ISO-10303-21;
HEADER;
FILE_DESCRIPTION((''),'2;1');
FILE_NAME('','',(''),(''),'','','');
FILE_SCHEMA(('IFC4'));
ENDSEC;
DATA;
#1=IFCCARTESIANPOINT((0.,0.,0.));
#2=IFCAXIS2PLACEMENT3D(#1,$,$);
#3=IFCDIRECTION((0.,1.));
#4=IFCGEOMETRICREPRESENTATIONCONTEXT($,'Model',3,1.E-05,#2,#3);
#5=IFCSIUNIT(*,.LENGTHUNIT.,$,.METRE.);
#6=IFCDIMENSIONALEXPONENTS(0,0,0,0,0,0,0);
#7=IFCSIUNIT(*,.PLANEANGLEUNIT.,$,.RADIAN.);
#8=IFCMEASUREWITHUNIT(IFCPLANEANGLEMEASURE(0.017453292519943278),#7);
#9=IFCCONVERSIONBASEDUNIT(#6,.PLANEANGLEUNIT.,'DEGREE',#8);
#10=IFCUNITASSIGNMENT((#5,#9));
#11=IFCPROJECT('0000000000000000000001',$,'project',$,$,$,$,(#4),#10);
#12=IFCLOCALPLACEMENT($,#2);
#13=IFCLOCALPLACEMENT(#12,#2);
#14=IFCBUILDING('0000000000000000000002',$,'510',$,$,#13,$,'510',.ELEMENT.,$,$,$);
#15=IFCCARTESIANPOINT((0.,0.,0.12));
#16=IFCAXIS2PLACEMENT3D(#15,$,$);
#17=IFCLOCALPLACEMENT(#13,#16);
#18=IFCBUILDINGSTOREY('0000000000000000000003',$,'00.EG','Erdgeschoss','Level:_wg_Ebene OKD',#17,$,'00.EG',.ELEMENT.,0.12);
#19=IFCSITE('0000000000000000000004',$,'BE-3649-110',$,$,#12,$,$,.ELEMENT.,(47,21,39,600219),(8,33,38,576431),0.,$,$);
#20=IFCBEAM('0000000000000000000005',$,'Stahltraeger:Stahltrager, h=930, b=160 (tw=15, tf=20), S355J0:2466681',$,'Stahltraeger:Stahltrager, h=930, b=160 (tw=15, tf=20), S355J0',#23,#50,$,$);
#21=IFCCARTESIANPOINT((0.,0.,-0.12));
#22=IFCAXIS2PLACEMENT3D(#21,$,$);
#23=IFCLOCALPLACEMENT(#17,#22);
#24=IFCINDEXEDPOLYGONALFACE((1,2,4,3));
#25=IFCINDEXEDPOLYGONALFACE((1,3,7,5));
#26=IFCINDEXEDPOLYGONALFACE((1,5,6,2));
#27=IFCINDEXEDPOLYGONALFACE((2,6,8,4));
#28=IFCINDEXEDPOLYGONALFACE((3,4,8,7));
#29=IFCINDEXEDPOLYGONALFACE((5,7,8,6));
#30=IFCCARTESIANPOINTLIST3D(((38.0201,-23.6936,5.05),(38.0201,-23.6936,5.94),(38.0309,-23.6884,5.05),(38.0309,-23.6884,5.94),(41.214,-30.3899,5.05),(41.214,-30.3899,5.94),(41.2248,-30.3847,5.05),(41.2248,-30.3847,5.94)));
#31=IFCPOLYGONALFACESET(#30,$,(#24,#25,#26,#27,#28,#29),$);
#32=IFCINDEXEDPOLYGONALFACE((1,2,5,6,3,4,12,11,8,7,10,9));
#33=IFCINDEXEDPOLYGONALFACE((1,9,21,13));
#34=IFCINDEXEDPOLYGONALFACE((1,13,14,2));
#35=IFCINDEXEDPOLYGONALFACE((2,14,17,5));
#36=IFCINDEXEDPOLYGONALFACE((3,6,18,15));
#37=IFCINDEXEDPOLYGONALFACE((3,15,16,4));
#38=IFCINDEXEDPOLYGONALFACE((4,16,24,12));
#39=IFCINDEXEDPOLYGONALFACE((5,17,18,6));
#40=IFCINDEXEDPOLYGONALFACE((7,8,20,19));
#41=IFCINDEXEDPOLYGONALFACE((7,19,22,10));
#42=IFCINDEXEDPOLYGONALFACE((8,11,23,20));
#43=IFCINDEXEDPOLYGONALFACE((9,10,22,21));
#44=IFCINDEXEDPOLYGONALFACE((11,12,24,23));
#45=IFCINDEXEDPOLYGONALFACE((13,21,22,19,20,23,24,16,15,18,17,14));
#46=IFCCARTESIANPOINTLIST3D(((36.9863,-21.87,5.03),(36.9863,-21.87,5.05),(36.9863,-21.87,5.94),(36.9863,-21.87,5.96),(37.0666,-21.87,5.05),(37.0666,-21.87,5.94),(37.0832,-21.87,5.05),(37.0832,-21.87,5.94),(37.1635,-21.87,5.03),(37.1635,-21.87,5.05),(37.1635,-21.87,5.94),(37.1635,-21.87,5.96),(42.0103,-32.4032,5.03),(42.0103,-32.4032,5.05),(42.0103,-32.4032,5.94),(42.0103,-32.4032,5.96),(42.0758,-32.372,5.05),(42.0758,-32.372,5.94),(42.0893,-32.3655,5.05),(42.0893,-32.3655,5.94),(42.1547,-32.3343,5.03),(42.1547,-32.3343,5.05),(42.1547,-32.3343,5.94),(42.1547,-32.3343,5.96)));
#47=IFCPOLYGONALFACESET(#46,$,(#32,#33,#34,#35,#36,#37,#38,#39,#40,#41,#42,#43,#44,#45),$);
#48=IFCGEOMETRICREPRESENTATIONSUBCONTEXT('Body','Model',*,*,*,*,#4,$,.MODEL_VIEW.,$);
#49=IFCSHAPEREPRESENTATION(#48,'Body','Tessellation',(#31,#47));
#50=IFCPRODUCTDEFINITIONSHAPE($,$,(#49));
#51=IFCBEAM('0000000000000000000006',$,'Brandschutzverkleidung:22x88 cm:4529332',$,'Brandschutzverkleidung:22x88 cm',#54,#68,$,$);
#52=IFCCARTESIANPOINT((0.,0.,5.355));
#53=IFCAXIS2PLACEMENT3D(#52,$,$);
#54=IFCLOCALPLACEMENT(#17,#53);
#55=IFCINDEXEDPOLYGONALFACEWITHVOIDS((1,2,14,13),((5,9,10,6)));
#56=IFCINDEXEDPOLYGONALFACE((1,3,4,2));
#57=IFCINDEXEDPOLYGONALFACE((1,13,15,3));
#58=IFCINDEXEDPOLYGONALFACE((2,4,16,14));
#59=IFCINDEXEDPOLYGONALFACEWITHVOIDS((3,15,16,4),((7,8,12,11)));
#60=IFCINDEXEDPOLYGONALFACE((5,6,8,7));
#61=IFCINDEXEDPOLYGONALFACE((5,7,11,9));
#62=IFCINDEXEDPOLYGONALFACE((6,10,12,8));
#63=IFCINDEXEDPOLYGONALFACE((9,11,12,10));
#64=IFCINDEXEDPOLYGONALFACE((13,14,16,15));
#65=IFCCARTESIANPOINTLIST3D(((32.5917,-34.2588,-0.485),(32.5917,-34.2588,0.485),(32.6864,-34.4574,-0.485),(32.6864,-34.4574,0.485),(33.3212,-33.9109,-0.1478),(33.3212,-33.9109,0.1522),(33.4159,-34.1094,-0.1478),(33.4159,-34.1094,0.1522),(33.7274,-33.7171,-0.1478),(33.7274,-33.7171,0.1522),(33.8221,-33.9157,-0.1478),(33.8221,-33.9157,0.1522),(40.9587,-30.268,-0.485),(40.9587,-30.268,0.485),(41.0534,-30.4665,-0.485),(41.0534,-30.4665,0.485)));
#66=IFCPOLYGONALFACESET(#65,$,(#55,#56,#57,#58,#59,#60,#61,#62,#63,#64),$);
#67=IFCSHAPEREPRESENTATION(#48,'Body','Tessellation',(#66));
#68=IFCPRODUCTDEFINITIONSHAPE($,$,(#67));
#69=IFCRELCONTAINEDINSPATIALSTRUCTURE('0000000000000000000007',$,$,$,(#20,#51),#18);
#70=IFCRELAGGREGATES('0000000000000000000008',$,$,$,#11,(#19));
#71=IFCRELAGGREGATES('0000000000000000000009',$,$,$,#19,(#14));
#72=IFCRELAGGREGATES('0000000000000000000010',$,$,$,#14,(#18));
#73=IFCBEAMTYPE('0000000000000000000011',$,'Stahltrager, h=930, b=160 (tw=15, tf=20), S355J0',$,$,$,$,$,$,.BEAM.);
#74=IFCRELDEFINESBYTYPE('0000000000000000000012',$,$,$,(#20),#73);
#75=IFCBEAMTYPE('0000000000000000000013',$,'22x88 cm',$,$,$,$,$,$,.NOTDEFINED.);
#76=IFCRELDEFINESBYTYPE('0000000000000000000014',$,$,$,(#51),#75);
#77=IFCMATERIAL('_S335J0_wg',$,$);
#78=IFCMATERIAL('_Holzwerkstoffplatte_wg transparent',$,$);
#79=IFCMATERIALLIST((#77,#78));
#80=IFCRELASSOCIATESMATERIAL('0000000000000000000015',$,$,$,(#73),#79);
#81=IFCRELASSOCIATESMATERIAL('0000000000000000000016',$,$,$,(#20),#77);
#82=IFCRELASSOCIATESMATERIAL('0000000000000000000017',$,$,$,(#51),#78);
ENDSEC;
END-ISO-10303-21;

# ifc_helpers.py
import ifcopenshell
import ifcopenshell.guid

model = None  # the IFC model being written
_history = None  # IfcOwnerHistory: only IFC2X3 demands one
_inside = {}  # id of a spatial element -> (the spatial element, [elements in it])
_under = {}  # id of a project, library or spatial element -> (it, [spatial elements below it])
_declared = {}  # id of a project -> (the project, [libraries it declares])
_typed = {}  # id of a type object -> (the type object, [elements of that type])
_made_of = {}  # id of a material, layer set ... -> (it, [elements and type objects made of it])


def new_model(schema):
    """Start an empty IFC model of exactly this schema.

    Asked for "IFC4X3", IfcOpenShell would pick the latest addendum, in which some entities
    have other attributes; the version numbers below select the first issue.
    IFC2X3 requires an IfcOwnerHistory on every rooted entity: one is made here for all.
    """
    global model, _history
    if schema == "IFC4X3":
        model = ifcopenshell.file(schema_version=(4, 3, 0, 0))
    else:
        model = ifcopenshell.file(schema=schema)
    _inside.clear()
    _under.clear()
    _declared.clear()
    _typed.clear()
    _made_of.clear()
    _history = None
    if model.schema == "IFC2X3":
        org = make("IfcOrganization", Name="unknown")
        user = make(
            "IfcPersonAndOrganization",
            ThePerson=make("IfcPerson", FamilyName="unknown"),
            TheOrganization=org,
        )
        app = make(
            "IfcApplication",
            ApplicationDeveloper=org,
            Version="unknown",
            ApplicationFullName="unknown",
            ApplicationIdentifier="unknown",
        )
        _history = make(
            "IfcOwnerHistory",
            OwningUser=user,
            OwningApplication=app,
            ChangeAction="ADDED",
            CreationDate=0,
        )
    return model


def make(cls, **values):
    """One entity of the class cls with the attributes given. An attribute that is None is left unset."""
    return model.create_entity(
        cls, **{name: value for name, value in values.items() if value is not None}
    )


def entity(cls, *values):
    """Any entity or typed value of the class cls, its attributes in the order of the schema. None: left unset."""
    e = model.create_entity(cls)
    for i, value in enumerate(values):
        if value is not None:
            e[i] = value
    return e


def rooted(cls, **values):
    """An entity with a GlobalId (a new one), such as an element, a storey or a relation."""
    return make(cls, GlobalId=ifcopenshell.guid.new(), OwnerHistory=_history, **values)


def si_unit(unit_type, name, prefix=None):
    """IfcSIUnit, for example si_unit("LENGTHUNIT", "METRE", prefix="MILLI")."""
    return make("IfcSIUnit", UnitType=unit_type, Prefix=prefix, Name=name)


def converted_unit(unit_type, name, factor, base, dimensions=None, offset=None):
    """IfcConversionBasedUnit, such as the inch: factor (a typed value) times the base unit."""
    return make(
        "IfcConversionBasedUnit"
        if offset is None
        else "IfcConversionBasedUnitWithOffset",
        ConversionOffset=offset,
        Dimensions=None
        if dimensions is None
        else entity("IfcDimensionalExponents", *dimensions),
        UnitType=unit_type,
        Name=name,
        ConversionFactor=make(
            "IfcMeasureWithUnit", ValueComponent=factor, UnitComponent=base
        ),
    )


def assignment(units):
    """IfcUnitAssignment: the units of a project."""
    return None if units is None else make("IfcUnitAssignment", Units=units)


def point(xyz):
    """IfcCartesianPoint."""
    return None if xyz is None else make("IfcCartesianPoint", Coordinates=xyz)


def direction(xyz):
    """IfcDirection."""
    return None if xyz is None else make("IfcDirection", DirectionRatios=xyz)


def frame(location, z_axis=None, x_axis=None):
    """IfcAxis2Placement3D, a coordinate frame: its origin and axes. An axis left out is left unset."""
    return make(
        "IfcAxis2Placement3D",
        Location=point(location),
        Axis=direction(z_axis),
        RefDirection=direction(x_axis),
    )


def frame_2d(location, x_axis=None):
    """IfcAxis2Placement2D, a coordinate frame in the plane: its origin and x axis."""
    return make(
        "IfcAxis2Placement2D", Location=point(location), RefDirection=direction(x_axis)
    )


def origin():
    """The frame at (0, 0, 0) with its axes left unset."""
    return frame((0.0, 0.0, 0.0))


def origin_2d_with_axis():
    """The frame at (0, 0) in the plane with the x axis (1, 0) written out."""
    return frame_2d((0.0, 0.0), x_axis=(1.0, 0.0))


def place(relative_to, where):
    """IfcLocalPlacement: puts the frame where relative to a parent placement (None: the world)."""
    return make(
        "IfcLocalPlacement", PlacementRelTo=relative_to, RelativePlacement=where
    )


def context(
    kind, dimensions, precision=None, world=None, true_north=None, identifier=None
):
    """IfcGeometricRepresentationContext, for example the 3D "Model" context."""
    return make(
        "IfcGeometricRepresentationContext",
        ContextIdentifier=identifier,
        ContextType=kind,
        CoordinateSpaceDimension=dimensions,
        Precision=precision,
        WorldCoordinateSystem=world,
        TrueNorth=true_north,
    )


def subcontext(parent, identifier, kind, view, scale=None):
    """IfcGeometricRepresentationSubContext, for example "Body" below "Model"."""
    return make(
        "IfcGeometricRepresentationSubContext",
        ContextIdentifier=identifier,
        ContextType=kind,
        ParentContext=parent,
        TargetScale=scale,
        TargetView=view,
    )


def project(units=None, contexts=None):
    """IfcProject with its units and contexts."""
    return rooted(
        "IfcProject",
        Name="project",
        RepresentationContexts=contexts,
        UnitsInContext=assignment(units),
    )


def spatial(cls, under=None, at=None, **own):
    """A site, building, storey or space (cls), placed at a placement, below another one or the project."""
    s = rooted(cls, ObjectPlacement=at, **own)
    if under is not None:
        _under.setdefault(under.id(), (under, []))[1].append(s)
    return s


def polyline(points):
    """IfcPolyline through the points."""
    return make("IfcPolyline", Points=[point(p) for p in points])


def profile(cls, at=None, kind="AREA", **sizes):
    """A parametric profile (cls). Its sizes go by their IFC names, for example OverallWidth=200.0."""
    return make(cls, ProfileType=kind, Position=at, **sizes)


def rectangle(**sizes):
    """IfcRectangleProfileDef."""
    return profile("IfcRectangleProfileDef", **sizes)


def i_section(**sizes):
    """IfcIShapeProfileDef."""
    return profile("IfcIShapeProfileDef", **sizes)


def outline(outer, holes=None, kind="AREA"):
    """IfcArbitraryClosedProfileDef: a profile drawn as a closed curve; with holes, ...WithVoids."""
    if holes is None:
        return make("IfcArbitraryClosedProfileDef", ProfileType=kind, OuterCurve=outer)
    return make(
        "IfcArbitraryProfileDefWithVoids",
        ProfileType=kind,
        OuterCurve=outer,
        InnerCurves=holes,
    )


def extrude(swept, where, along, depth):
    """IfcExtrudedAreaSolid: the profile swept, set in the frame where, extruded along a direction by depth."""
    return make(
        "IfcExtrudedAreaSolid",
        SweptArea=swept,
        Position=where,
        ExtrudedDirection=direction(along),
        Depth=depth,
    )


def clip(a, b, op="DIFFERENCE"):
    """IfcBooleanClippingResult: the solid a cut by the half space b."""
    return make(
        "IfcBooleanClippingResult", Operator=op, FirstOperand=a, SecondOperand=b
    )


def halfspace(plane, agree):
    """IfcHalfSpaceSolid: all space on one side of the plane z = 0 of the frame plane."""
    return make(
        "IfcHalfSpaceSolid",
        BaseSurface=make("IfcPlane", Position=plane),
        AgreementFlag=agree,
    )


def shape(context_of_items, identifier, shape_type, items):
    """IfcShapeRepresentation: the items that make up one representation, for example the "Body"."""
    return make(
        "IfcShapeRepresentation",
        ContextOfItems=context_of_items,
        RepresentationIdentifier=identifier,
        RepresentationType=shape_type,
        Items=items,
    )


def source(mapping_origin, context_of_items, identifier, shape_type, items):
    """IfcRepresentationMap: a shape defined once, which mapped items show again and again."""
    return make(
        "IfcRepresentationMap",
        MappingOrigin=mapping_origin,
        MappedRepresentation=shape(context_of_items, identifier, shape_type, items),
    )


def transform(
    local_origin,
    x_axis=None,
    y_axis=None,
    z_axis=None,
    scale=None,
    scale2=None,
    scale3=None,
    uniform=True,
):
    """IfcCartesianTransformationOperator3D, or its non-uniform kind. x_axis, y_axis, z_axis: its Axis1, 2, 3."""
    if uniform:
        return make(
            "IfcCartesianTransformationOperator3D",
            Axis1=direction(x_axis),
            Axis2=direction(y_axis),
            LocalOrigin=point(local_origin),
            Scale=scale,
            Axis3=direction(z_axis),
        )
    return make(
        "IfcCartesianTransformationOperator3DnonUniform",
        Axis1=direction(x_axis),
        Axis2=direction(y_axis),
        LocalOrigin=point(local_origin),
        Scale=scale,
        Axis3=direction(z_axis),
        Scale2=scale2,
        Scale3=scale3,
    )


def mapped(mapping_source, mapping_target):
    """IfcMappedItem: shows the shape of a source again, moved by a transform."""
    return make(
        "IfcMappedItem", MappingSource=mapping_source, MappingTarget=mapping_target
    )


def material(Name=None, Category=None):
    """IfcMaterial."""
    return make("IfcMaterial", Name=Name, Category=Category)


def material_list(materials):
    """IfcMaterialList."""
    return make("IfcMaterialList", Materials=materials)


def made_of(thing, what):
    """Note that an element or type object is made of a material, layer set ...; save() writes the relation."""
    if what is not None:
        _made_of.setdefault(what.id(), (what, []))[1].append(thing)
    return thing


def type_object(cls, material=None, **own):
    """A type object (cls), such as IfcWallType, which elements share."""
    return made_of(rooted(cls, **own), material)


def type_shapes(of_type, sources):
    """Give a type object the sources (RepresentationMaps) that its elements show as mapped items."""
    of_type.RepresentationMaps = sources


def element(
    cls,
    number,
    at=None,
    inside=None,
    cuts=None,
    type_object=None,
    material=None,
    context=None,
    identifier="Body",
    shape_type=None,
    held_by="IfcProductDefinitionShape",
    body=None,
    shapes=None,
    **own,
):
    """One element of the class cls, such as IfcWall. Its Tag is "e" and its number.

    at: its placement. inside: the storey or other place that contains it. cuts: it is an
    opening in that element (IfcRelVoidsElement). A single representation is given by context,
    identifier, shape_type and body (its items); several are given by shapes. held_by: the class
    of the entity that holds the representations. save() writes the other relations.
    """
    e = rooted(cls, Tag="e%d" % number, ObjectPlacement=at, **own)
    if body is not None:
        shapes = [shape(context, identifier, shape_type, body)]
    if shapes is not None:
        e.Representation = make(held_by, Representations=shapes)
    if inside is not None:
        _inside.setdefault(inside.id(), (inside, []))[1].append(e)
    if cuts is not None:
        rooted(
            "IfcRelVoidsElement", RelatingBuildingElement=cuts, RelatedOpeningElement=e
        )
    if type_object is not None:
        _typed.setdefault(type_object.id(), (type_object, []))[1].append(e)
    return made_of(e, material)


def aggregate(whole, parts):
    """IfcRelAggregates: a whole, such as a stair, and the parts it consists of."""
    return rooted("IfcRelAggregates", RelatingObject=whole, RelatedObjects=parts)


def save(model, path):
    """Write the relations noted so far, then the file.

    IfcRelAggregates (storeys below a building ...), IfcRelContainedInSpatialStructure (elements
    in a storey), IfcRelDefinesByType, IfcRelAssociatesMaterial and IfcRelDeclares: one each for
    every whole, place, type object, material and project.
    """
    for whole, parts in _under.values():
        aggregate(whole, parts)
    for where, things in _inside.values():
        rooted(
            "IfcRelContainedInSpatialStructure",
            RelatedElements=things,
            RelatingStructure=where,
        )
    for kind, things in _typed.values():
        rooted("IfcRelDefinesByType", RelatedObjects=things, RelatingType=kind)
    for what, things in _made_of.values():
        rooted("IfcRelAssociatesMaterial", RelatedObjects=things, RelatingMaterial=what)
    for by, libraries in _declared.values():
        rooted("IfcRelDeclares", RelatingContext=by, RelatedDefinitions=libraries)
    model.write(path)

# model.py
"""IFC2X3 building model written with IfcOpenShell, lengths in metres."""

from ifc_helpers import new_model, entity, si_unit, converted_unit, direction, frame, frame_2d, origin, origin_2d_with_axis, place, context, subcontext, project, spatial, polyline, rectangle, i_section, outline, extrude, clip, halfspace, source, transform, mapped, material, material_list, type_object, type_shapes, element, save


model = new_model("IFC2X3")

# Units and contexts
model_context = context("Model", 3, precision=1e-05, world=origin(), true_north=direction((0.0, 1.0)))
body_context = subcontext(model_context, "Body", "Model", "MODEL_VIEW")
ifc_project = project(units=[si_unit("LENGTHUNIT", "METRE"), converted_unit("PLANEANGLEUNIT", "DEGREE", entity("IfcPlaneAngleMeasure", 0.017453292519943278), si_unit("PLANEANGLEUNIT", "RADIAN"), dimensions=[0, 0, 0, 0, 0, 0, 0])], contexts=[model_context])

# Site, building, storey
site_placement = place(None, origin())
site = spatial("IfcSite", under=ifc_project, at=site_placement, Name="BE-3649-110", CompositionType="ELEMENT", RefLatitude=(47, 21, 39, 600219), RefLongitude=(8, 33, 38, 576431), RefElevation=0.0)
building_placement = place(site_placement, origin())
building = spatial("IfcBuilding", under=site, at=building_placement, Name="510", LongName="510", CompositionType="ELEMENT")
storey_placement = place(building_placement, frame((0.0, 0.0, 0.12)))
storey = spatial("IfcBuildingStorey", under=building, at=storey_placement, Name="00.EG", Description="Erdgeschoss", ObjectType="Level:_wg_Ebene OKD", LongName="00.EG", CompositionType="ELEMENT", Elevation=0.12)

# Beams
ifc_material_1 = material(Name="_S335J0_wg")
ifc_material_2 = material(Name="_Holzwerkstoffplatte_wg transparent")
ifc_material_list = material_list([ifc_material_1, ifc_material_2])
beam_type_1 = type_object("IfcBeamType", Name="Stahltrager, h=930, b=160 (tw=15, tf=20), S355J0", PredefinedType="BEAM", material=ifc_material_list)
shared_shape_1 = source(origin(), body_context, "Body", "SweptSolid", [
    extrude(rectangle(XDim=0.89, YDim=0.012, at=origin_2d_with_axis()), frame((38.0255, -23.691, 5.495), z_axis=(0.430511, -0.902585, 0.0), x_axis=(0.0, 0.0, -1.0)), (0.0, 0.0, 1.0), 7.419),
    clip(extrude(i_section(OverallWidth=0.16, OverallDepth=0.93, WebThickness=0.015, FlangeThickness=0.02, at=frame_2d((0.0, 0.0), x_axis=(0.0, 1.0))), frame((37.0585, -21.8356, 5.495), z_axis=(0.430511, -0.902585, 0.0), x_axis=(0.0, 0.0, -1.0)), (0.0, 0.0, 1.0), 11.67), halfspace(frame((38.1879, -21.87, -6.323), z_axis=(0.0, 1.0, 0.0), x_axis=(0.0, 0.0, 1.0)), False)),
])
type_shapes(beam_type_1, [shared_shape_1])
beam_1_placement = place(storey_placement, frame((0.0, 0.0, -0.12)))
element("IfcBeam", 1, at=beam_1_placement, inside=storey, type_object=beam_type_1, material=ifc_material_1, Name="Stahltraeger:Stahltrager, h=930, b=160 (tw=15, tf=20), S355J0:2466681", ObjectType="Stahltraeger:Stahltrager, h=930, b=160 (tw=15, tf=20), S355J0", context=body_context, shape_type="MappedRepresentation", body=[
    mapped(shared_shape_1, transform((0.0, 0.0, 0.0), scale=1.0)),
])
beam_type_2 = type_object("IfcBeamType", Name="22x88 cm", PredefinedType="NOTDEFINED")
beam_2_placement = place(storey_placement, frame((0.0, 0.0, 5.355)))
element("IfcBeam", 2, at=beam_2_placement, inside=storey, type_object=beam_type_2, material=ifc_material_2, Name="Brandschutzverkleidung:22x88 cm:4529332", ObjectType="Brandschutzverkleidung:22x88 cm", context=body_context, shape_type="SweptSolid", body=[
    extrude(outline(polyline([(-4.635, -0.485), (4.635, -0.485), (4.635, 0.485), (-4.635, 0.485), (-4.635, -0.485)]), holes=[polyline([(-3.3767, 0.1478), (-3.3767, -0.1522), (-3.8267, -0.1522), (-3.8267, 0.1478), (-3.3767, 0.1478)])]), frame((36.8699, -32.462, 0.0), z_axis=(-0.430511, 0.902585, 0.0), x_axis=(0.902585, 0.430511, 0.0)), (0.0, 0.0, 1.0), 0.22),
])

save(model, "model.ifc")
